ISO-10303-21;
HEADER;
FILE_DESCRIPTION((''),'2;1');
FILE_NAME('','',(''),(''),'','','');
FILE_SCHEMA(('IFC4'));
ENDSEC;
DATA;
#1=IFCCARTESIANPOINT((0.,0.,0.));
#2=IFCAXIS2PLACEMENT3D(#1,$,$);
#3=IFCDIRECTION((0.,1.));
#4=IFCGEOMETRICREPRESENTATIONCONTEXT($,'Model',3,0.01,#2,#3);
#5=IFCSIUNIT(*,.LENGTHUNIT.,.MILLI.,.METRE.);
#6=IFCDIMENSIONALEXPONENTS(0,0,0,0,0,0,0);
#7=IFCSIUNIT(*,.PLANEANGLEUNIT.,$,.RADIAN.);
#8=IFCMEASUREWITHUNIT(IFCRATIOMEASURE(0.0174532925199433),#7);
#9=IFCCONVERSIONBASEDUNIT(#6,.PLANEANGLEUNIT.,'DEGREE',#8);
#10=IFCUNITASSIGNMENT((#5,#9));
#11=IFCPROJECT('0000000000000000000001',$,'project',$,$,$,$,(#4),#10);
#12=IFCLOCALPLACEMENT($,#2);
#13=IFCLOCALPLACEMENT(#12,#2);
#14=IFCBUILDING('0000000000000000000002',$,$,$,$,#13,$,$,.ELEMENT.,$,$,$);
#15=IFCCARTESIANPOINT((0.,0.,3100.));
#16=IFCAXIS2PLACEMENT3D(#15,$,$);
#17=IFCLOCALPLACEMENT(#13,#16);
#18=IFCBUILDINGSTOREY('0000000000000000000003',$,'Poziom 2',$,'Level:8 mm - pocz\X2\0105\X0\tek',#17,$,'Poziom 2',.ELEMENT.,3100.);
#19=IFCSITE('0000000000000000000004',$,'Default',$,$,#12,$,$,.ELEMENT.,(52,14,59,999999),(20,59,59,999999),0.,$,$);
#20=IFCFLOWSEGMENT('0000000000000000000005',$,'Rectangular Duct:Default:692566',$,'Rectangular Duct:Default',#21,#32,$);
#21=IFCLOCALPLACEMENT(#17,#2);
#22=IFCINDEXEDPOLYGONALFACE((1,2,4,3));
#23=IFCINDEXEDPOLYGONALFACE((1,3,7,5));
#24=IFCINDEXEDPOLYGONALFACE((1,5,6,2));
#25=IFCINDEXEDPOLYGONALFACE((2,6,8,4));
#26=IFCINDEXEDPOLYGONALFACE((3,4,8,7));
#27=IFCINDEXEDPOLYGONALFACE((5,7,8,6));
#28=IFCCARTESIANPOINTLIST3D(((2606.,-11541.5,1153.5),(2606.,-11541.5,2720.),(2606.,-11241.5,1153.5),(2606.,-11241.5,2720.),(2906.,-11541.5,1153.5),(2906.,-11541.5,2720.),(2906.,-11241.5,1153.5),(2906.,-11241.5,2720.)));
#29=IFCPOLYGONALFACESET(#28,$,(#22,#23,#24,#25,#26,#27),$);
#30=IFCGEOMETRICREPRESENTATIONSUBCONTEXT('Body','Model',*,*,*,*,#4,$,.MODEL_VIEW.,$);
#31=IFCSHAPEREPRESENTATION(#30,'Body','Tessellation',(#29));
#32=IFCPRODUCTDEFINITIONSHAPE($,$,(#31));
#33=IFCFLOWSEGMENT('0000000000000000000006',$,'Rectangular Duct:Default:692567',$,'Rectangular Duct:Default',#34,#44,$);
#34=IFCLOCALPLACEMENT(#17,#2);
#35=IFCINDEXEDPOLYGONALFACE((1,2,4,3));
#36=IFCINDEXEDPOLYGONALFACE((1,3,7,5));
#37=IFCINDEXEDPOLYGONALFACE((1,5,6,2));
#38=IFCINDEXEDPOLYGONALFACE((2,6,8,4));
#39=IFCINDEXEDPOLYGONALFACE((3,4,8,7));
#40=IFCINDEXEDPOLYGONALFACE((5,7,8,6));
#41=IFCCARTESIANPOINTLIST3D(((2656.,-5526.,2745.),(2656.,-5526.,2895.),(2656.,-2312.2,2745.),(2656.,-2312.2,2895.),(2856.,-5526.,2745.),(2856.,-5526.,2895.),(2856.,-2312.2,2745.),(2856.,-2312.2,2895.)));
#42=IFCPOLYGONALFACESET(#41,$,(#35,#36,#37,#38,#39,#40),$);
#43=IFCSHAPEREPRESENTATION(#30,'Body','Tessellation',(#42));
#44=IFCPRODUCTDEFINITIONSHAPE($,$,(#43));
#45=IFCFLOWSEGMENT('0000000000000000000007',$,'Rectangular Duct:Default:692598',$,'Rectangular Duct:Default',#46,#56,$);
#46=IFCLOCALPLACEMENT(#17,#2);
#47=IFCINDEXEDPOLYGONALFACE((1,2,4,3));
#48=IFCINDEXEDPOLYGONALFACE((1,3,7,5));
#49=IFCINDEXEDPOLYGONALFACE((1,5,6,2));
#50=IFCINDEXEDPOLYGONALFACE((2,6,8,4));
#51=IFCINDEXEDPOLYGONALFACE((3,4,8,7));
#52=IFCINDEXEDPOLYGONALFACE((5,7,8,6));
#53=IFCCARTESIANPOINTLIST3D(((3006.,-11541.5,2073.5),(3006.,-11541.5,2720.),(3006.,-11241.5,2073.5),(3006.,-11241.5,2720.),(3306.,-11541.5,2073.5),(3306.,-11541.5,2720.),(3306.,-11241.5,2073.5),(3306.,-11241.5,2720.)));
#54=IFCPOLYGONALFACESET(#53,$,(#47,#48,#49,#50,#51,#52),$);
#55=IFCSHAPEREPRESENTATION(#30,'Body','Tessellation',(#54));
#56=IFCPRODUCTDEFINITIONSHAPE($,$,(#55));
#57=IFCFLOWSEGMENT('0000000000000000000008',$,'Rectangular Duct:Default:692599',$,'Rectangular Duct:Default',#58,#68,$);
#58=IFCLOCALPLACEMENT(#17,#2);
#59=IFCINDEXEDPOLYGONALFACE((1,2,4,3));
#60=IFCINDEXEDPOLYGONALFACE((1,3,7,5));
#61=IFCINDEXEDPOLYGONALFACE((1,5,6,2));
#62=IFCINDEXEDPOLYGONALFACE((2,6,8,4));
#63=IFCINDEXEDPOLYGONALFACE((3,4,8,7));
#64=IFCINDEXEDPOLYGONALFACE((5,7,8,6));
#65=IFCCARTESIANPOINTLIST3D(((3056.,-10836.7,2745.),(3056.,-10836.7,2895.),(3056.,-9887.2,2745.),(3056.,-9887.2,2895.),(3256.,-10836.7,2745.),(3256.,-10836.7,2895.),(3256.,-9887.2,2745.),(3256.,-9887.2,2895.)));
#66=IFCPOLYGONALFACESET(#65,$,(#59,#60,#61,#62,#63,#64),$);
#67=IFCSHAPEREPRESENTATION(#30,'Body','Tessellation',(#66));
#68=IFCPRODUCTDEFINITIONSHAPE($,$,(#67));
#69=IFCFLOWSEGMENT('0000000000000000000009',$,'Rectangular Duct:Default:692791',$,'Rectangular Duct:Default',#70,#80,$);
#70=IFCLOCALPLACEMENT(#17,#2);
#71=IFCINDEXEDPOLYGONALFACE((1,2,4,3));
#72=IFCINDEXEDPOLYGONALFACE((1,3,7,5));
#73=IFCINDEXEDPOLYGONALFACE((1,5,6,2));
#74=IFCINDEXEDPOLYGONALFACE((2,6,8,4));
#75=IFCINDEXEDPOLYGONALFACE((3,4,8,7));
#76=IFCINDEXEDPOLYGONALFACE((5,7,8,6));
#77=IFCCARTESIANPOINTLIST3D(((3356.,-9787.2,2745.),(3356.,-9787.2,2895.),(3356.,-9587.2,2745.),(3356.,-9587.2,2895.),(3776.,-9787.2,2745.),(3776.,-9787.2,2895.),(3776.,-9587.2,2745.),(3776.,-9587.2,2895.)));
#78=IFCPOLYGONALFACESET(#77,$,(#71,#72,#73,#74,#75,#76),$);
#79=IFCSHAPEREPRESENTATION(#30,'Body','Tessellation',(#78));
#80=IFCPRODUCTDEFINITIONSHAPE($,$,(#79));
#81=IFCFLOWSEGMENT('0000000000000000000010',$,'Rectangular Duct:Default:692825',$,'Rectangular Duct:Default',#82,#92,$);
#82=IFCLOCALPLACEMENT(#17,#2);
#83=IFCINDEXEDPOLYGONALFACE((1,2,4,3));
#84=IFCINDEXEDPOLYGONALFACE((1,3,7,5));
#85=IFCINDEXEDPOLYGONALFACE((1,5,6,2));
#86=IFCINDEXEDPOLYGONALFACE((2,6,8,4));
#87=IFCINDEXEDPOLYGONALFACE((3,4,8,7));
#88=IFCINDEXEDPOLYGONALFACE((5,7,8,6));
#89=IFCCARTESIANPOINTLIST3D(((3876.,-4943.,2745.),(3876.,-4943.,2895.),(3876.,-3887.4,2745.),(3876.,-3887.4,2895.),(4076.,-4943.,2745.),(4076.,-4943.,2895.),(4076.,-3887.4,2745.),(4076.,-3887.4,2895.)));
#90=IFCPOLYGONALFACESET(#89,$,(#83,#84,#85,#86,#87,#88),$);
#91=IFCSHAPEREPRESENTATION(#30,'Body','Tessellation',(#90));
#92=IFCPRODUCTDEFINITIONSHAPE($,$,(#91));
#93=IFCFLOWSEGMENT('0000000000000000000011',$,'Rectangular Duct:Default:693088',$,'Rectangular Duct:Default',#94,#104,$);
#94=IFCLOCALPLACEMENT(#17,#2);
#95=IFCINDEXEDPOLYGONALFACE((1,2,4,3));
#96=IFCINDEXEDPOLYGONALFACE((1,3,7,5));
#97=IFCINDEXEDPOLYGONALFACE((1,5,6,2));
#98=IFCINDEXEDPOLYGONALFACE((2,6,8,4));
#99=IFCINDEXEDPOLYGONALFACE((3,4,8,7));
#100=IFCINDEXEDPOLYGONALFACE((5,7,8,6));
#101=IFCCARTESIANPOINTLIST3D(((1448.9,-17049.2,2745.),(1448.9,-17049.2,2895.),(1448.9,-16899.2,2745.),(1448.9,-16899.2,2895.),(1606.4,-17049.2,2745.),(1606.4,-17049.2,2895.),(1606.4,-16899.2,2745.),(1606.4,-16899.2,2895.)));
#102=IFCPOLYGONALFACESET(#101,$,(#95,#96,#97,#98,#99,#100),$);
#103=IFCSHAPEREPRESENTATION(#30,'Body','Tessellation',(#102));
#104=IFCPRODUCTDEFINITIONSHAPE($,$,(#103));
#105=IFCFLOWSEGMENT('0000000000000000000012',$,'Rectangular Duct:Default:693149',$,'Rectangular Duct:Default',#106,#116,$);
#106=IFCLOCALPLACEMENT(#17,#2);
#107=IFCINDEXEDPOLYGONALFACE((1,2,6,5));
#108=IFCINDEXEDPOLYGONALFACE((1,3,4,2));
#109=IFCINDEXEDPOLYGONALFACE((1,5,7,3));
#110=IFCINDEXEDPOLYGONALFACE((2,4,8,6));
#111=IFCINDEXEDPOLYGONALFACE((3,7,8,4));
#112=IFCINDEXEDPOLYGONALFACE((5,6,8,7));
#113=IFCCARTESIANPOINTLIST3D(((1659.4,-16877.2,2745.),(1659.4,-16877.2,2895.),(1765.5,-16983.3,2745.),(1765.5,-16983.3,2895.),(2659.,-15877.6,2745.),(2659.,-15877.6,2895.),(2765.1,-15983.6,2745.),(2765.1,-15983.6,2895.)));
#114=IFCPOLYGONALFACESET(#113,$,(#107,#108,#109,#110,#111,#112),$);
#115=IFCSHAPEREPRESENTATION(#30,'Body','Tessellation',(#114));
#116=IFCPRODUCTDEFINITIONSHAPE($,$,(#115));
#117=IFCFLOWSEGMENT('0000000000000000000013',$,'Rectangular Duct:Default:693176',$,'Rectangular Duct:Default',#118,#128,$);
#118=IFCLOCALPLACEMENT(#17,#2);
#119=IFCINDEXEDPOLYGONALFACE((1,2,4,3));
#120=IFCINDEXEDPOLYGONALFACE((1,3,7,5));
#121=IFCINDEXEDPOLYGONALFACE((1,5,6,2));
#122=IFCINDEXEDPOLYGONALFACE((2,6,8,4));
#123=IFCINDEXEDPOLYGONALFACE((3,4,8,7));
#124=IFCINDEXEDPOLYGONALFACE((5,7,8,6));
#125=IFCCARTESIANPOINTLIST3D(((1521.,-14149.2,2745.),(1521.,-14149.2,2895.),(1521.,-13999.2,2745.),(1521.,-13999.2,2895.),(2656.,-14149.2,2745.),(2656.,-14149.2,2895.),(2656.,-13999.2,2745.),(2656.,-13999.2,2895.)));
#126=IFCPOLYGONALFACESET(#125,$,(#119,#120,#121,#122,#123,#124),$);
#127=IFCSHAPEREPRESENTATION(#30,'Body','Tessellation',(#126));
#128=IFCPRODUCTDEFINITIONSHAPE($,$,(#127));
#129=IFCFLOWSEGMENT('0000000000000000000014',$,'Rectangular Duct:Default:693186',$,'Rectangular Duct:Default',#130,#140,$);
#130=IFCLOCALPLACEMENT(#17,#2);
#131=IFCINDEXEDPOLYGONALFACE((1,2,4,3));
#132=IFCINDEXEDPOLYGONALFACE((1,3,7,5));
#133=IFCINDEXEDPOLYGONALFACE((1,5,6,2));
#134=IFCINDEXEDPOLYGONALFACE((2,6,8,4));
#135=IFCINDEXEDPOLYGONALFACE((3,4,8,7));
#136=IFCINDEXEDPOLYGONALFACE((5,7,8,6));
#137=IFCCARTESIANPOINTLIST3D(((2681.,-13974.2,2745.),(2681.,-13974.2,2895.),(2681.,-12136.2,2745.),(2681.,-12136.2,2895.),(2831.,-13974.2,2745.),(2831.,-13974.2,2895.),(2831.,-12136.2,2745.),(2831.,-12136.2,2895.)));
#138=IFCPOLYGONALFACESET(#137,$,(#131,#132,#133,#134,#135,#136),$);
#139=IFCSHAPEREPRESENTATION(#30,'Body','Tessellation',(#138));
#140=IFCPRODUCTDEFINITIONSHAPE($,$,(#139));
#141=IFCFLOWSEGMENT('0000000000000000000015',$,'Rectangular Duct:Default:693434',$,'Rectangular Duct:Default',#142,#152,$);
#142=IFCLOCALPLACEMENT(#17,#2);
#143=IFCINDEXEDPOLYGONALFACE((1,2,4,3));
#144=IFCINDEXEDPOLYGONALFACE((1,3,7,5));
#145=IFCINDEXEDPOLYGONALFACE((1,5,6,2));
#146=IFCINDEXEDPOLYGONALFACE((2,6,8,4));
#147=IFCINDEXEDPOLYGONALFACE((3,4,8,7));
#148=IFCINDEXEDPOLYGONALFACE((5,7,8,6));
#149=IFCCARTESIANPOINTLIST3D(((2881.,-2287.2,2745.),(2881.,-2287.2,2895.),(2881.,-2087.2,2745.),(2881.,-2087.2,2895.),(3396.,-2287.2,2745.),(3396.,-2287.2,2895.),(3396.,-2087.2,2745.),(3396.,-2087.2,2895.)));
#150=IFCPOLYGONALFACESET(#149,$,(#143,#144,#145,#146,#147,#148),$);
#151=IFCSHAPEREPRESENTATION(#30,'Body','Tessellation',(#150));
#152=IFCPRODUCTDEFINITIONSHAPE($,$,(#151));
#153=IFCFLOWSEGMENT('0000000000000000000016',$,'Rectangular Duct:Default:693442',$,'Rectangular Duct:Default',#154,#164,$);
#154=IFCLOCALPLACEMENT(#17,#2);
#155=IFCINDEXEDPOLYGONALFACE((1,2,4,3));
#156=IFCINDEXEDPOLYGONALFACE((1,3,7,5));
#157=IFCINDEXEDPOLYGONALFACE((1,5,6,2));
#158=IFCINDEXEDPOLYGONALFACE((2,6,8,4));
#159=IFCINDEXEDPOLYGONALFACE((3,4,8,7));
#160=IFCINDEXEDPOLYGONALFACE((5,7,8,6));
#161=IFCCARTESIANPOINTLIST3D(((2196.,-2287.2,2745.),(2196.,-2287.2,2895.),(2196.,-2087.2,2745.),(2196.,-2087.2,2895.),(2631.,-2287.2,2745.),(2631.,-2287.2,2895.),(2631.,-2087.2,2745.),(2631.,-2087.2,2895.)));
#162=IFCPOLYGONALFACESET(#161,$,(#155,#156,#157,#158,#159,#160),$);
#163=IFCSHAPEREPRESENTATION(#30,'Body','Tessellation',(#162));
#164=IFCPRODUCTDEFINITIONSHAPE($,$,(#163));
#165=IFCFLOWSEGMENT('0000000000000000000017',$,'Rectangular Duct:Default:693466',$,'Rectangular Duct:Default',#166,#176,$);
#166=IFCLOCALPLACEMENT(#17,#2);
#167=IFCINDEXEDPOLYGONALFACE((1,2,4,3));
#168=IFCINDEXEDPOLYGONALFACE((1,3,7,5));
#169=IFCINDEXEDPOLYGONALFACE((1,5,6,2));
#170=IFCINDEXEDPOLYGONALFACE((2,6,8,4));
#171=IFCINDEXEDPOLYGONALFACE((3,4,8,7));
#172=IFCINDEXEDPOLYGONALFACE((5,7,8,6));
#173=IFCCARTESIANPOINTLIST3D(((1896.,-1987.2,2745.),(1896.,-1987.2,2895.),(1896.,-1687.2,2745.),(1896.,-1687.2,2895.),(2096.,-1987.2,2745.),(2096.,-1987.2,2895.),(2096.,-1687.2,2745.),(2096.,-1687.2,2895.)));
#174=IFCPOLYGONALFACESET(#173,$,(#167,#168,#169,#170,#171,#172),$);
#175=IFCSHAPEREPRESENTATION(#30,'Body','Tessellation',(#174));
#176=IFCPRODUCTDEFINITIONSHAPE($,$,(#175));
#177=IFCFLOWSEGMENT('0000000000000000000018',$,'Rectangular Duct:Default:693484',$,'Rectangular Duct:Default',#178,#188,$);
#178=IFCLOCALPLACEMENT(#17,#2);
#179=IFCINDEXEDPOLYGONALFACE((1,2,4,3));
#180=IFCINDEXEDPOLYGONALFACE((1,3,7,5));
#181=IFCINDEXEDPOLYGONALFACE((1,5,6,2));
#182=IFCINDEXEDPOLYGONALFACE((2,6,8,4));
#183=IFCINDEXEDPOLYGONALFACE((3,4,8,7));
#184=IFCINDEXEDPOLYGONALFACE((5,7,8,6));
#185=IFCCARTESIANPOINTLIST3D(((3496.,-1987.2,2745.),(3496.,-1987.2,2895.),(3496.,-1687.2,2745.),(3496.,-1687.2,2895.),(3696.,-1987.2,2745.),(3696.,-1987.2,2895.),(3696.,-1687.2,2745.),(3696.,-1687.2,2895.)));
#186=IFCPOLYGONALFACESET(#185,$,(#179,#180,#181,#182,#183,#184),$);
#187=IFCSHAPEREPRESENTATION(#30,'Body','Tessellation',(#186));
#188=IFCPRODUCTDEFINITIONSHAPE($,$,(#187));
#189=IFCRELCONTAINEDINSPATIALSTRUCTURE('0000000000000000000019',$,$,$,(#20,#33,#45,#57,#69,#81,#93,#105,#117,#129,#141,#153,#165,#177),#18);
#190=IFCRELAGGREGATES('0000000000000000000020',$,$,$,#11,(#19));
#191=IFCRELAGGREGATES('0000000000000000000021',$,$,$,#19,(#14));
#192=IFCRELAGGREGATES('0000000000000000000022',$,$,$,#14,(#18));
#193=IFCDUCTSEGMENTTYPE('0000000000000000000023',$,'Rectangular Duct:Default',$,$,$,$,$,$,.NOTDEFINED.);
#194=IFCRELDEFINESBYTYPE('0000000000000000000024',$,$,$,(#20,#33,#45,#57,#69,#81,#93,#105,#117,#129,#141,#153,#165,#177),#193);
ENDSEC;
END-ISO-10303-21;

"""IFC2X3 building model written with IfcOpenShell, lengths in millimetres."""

from ifc_helpers import new_model, entity, si_unit, converted_unit, direction, frame, frame_2d, origin, origin_2d_with_axis, place, context, subcontext, project, spatial, rectangle, extrude, type_object, element, save


model = new_model("IFC2X3")

# Units and contexts
model_context = context("Model", 3, precision=0.01, world=origin(), true_north=direction((0.0, 1.0)))
body_context = subcontext(model_context, "Body", "Model", "MODEL_VIEW")
ifc_project = project(units=[si_unit("LENGTHUNIT", "METRE", prefix="MILLI"), converted_unit("PLANEANGLEUNIT", "DEGREE", entity("IfcRatioMeasure", 0.0174532925199433), si_unit("PLANEANGLEUNIT", "RADIAN"), dimensions=[0, 0, 0, 0, 0, 0, 0])], contexts=[model_context])

# Site, building, storey
site_placement = place(None, origin())
site = spatial("IfcSite", under=ifc_project, at=site_placement, Name="Default", CompositionType="ELEMENT", RefLatitude=(52, 14, 59, 999999), RefLongitude=(20, 59, 59, 999999), RefElevation=0.0)
building_placement = place(site_placement, origin())
building = spatial("IfcBuilding", under=site, at=building_placement, CompositionType="ELEMENT")
storey_placement = place(building_placement, frame((0.0, 0.0, 3100.0)))
storey = spatial("IfcBuildingStorey", under=building, at=storey_placement, Name="Poziom 2", ObjectType="Level:8 mm - początek", LongName="Poziom 2", CompositionType="ELEMENT", Elevation=3100.0)

# Flow segments
duct_segment_type = type_object("IfcDuctSegmentType", Name="Rectangular Duct:Default", PredefinedType="NOTDEFINED")
flow_segment_1_placement = place(storey_placement, origin())
element("IfcFlowSegment", 1, at=flow_segment_1_placement, inside=storey, type_object=duct_segment_type, Name="Rectangular Duct:Default:692566", ObjectType="Rectangular Duct:Default", context=body_context, shape_type="SweptSolid", body=[
    extrude(rectangle(XDim=300.0, YDim=300.0, at=frame_2d((0.0, 0.0), x_axis=(1.0, 0.0))), frame((2756.0, -11391.5, 1153.5), z_axis=(0.0, 0.0, 1.0), x_axis=(0.0, 1.0, 0.0)), (0.0, 0.0, 1.0), 1566.5),
])
flow_segment_2_placement = place(storey_placement, origin())
element("IfcFlowSegment", 2, at=flow_segment_2_placement, inside=storey, type_object=duct_segment_type, Name="Rectangular Duct:Default:692567", ObjectType="Rectangular Duct:Default", context=body_context, shape_type="SweptSolid", body=[
    extrude(rectangle(XDim=3213.8, YDim=200.0, at=frame_2d((0.0, 0.0), x_axis=(1.0, 0.0))), frame((2756.0, -3919.1, 2745.0), z_axis=(0.0, 0.0, 1.0), x_axis=(0.0, 1.0, 0.0)), (0.0, 0.0, 1.0), 150.0),
])
flow_segment_3_placement = place(storey_placement, origin())
element("IfcFlowSegment", 3, at=flow_segment_3_placement, inside=storey, type_object=duct_segment_type, Name="Rectangular Duct:Default:692598", ObjectType="Rectangular Duct:Default", context=body_context, shape_type="SweptSolid", body=[
    extrude(rectangle(XDim=300.0, YDim=300.0, at=origin_2d_with_axis()), frame((3156.0, -11391.5, 2073.5), z_axis=(0.0, 0.0, 1.0), x_axis=(0.0, -1.0, 0.0)), (0.0, 0.0, 1.0), 646.5),
])
flow_segment_4_placement = place(storey_placement, origin())
element("IfcFlowSegment", 4, at=flow_segment_4_placement, inside=storey, type_object=duct_segment_type, Name="Rectangular Duct:Default:692599", ObjectType="Rectangular Duct:Default", context=body_context, shape_type="SweptSolid", body=[
    extrude(rectangle(XDim=949.5, YDim=200.0, at=frame_2d((0.0, 0.0), x_axis=(1.0, 0.0))), frame((3156.0, -10362.0, 2745.0), z_axis=(0.0, 0.0, 1.0), x_axis=(0.0, 1.0, 0.0)), (0.0, 0.0, 1.0), 150.0),
])
flow_segment_5_placement = place(storey_placement, origin())
element("IfcFlowSegment", 5, at=flow_segment_5_placement, inside=storey, type_object=duct_segment_type, Name="Rectangular Duct:Default:692791", ObjectType="Rectangular Duct:Default", context=body_context, shape_type="SweptSolid", body=[
    extrude(rectangle(XDim=420.0, YDim=200.0, at=frame_2d((0.0, 0.0), x_axis=(1.0, 0.0))), frame((3566.0, -9687.2, 2745.0)), (0.0, 0.0, 1.0), 150.0),
])
flow_segment_6_placement = place(storey_placement, origin())
element("IfcFlowSegment", 6, at=flow_segment_6_placement, inside=storey, type_object=duct_segment_type, Name="Rectangular Duct:Default:692825", ObjectType="Rectangular Duct:Default", context=body_context, shape_type="SweptSolid", body=[
    extrude(rectangle(XDim=1055.6, YDim=200.0, at=frame_2d((0.0, 0.0), x_axis=(1.0, 0.0))), frame((3976.0, -4415.2, 2745.0), z_axis=(0.0, 0.0, 1.0), x_axis=(0.0, 1.0, 0.0)), (0.0, 0.0, 1.0), 150.0),
])
flow_segment_7_placement = place(storey_placement, origin())
element("IfcFlowSegment", 7, at=flow_segment_7_placement, inside=storey, type_object=duct_segment_type, Name="Rectangular Duct:Default:693088", ObjectType="Rectangular Duct:Default", context=body_context, shape_type="SweptSolid", body=[
    extrude(rectangle(XDim=157.5, YDim=150.0, at=frame_2d((0.0, 0.0), x_axis=(1.0, 0.0))), frame((1527.6, -16974.2, 2745.0), z_axis=(0.0, 0.0, 1.0), x_axis=(-1.0, 0.0, 0.0)), (0.0, 0.0, 1.0), 150.0),
])
flow_segment_8_placement = place(storey_placement, origin())
element("IfcFlowSegment", 8, at=flow_segment_8_placement, inside=storey, type_object=duct_segment_type, Name="Rectangular Duct:Default:693149", ObjectType="Rectangular Duct:Default", context=body_context, shape_type="SweptSolid", body=[
    extrude(rectangle(XDim=1413.7, YDim=150.0, at=origin_2d_with_axis()), frame((2212.3, -16430.4, 2745.0), z_axis=(0.0, 0.0, 1.0), x_axis=(-0.707107, -0.707107, 0.0)), (0.0, 0.0, 1.0), 150.0),
])
flow_segment_9_placement = place(storey_placement, origin())
element("IfcFlowSegment", 9, at=flow_segment_9_placement, inside=storey, type_object=duct_segment_type, Name="Rectangular Duct:Default:693176", ObjectType="Rectangular Duct:Default", context=body_context, shape_type="SweptSolid", body=[
    extrude(rectangle(XDim=1135.0, YDim=150.0, at=frame_2d((0.0, 0.0), x_axis=(1.0, 0.0))), frame((2088.5, -14074.2, 2745.0), z_axis=(0.0, 0.0, 1.0), x_axis=(-1.0, 0.0, 0.0)), (0.0, 0.0, 1.0), 150.0),
])
flow_segment_10_placement = place(storey_placement, origin())
element("IfcFlowSegment", 10, at=flow_segment_10_placement, inside=storey, type_object=duct_segment_type, Name="Rectangular Duct:Default:693186", ObjectType="Rectangular Duct:Default", context=body_context, shape_type="SweptSolid", body=[
    extrude(rectangle(XDim=1838.0, YDim=150.0, at=frame_2d((0.0, 0.0), x_axis=(1.0, 0.0))), frame((2756.0, -13055.2, 2745.0), z_axis=(0.0, 0.0, 1.0), x_axis=(0.0, -1.0, 0.0)), (0.0, 0.0, 1.0), 150.0),
])
flow_segment_11_placement = place(storey_placement, origin())
element("IfcFlowSegment", 11, at=flow_segment_11_placement, inside=storey, type_object=duct_segment_type, Name="Rectangular Duct:Default:693434", ObjectType="Rectangular Duct:Default", context=body_context, shape_type="SweptSolid", body=[
    extrude(rectangle(XDim=515.0, YDim=200.0, at=frame_2d((0.0, 0.0), x_axis=(1.0, 0.0))), frame((3138.5, -2187.2, 2745.0)), (0.0, 0.0, 1.0), 150.0),
])
flow_segment_12_placement = place(storey_placement, origin())
element("IfcFlowSegment", 12, at=flow_segment_12_placement, inside=storey, type_object=duct_segment_type, Name="Rectangular Duct:Default:693442", ObjectType="Rectangular Duct:Default", context=body_context, shape_type="SweptSolid", body=[
    extrude(rectangle(XDim=435.0, YDim=200.0, at=frame_2d((0.0, 0.0), x_axis=(1.0, 0.0))), frame((2413.5, -2187.2, 2745.0)), (0.0, 0.0, 1.0), 150.0),
])
flow_segment_13_placement = place(storey_placement, origin())
element("IfcFlowSegment", 13, at=flow_segment_13_placement, inside=storey, type_object=duct_segment_type, Name="Rectangular Duct:Default:693466", ObjectType="Rectangular Duct:Default", context=body_context, shape_type="SweptSolid", body=[
    extrude(rectangle(XDim=300.0, YDim=200.0, at=frame_2d((0.0, 0.0), x_axis=(1.0, 0.0))), frame((1996.0, -1837.2, 2745.0), z_axis=(0.0, 0.0, 1.0), x_axis=(0.0, 1.0, 0.0)), (0.0, 0.0, 1.0), 150.0),
])
flow_segment_14_placement = place(storey_placement, origin())
element("IfcFlowSegment", 14, at=flow_segment_14_placement, inside=storey, type_object=duct_segment_type, Name="Rectangular Duct:Default:693484", ObjectType="Rectangular Duct:Default", context=body_context, shape_type="SweptSolid", body=[
    extrude(rectangle(XDim=300.0, YDim=200.0, at=frame_2d((0.0, 0.0), x_axis=(1.0, 0.0))), frame((3596.0, -1837.2, 2745.0), z_axis=(0.0, 0.0, 1.0), x_axis=(0.0, 1.0, 0.0)), (0.0, 0.0, 1.0), 150.0),
])

save(model, "model.ifc")
